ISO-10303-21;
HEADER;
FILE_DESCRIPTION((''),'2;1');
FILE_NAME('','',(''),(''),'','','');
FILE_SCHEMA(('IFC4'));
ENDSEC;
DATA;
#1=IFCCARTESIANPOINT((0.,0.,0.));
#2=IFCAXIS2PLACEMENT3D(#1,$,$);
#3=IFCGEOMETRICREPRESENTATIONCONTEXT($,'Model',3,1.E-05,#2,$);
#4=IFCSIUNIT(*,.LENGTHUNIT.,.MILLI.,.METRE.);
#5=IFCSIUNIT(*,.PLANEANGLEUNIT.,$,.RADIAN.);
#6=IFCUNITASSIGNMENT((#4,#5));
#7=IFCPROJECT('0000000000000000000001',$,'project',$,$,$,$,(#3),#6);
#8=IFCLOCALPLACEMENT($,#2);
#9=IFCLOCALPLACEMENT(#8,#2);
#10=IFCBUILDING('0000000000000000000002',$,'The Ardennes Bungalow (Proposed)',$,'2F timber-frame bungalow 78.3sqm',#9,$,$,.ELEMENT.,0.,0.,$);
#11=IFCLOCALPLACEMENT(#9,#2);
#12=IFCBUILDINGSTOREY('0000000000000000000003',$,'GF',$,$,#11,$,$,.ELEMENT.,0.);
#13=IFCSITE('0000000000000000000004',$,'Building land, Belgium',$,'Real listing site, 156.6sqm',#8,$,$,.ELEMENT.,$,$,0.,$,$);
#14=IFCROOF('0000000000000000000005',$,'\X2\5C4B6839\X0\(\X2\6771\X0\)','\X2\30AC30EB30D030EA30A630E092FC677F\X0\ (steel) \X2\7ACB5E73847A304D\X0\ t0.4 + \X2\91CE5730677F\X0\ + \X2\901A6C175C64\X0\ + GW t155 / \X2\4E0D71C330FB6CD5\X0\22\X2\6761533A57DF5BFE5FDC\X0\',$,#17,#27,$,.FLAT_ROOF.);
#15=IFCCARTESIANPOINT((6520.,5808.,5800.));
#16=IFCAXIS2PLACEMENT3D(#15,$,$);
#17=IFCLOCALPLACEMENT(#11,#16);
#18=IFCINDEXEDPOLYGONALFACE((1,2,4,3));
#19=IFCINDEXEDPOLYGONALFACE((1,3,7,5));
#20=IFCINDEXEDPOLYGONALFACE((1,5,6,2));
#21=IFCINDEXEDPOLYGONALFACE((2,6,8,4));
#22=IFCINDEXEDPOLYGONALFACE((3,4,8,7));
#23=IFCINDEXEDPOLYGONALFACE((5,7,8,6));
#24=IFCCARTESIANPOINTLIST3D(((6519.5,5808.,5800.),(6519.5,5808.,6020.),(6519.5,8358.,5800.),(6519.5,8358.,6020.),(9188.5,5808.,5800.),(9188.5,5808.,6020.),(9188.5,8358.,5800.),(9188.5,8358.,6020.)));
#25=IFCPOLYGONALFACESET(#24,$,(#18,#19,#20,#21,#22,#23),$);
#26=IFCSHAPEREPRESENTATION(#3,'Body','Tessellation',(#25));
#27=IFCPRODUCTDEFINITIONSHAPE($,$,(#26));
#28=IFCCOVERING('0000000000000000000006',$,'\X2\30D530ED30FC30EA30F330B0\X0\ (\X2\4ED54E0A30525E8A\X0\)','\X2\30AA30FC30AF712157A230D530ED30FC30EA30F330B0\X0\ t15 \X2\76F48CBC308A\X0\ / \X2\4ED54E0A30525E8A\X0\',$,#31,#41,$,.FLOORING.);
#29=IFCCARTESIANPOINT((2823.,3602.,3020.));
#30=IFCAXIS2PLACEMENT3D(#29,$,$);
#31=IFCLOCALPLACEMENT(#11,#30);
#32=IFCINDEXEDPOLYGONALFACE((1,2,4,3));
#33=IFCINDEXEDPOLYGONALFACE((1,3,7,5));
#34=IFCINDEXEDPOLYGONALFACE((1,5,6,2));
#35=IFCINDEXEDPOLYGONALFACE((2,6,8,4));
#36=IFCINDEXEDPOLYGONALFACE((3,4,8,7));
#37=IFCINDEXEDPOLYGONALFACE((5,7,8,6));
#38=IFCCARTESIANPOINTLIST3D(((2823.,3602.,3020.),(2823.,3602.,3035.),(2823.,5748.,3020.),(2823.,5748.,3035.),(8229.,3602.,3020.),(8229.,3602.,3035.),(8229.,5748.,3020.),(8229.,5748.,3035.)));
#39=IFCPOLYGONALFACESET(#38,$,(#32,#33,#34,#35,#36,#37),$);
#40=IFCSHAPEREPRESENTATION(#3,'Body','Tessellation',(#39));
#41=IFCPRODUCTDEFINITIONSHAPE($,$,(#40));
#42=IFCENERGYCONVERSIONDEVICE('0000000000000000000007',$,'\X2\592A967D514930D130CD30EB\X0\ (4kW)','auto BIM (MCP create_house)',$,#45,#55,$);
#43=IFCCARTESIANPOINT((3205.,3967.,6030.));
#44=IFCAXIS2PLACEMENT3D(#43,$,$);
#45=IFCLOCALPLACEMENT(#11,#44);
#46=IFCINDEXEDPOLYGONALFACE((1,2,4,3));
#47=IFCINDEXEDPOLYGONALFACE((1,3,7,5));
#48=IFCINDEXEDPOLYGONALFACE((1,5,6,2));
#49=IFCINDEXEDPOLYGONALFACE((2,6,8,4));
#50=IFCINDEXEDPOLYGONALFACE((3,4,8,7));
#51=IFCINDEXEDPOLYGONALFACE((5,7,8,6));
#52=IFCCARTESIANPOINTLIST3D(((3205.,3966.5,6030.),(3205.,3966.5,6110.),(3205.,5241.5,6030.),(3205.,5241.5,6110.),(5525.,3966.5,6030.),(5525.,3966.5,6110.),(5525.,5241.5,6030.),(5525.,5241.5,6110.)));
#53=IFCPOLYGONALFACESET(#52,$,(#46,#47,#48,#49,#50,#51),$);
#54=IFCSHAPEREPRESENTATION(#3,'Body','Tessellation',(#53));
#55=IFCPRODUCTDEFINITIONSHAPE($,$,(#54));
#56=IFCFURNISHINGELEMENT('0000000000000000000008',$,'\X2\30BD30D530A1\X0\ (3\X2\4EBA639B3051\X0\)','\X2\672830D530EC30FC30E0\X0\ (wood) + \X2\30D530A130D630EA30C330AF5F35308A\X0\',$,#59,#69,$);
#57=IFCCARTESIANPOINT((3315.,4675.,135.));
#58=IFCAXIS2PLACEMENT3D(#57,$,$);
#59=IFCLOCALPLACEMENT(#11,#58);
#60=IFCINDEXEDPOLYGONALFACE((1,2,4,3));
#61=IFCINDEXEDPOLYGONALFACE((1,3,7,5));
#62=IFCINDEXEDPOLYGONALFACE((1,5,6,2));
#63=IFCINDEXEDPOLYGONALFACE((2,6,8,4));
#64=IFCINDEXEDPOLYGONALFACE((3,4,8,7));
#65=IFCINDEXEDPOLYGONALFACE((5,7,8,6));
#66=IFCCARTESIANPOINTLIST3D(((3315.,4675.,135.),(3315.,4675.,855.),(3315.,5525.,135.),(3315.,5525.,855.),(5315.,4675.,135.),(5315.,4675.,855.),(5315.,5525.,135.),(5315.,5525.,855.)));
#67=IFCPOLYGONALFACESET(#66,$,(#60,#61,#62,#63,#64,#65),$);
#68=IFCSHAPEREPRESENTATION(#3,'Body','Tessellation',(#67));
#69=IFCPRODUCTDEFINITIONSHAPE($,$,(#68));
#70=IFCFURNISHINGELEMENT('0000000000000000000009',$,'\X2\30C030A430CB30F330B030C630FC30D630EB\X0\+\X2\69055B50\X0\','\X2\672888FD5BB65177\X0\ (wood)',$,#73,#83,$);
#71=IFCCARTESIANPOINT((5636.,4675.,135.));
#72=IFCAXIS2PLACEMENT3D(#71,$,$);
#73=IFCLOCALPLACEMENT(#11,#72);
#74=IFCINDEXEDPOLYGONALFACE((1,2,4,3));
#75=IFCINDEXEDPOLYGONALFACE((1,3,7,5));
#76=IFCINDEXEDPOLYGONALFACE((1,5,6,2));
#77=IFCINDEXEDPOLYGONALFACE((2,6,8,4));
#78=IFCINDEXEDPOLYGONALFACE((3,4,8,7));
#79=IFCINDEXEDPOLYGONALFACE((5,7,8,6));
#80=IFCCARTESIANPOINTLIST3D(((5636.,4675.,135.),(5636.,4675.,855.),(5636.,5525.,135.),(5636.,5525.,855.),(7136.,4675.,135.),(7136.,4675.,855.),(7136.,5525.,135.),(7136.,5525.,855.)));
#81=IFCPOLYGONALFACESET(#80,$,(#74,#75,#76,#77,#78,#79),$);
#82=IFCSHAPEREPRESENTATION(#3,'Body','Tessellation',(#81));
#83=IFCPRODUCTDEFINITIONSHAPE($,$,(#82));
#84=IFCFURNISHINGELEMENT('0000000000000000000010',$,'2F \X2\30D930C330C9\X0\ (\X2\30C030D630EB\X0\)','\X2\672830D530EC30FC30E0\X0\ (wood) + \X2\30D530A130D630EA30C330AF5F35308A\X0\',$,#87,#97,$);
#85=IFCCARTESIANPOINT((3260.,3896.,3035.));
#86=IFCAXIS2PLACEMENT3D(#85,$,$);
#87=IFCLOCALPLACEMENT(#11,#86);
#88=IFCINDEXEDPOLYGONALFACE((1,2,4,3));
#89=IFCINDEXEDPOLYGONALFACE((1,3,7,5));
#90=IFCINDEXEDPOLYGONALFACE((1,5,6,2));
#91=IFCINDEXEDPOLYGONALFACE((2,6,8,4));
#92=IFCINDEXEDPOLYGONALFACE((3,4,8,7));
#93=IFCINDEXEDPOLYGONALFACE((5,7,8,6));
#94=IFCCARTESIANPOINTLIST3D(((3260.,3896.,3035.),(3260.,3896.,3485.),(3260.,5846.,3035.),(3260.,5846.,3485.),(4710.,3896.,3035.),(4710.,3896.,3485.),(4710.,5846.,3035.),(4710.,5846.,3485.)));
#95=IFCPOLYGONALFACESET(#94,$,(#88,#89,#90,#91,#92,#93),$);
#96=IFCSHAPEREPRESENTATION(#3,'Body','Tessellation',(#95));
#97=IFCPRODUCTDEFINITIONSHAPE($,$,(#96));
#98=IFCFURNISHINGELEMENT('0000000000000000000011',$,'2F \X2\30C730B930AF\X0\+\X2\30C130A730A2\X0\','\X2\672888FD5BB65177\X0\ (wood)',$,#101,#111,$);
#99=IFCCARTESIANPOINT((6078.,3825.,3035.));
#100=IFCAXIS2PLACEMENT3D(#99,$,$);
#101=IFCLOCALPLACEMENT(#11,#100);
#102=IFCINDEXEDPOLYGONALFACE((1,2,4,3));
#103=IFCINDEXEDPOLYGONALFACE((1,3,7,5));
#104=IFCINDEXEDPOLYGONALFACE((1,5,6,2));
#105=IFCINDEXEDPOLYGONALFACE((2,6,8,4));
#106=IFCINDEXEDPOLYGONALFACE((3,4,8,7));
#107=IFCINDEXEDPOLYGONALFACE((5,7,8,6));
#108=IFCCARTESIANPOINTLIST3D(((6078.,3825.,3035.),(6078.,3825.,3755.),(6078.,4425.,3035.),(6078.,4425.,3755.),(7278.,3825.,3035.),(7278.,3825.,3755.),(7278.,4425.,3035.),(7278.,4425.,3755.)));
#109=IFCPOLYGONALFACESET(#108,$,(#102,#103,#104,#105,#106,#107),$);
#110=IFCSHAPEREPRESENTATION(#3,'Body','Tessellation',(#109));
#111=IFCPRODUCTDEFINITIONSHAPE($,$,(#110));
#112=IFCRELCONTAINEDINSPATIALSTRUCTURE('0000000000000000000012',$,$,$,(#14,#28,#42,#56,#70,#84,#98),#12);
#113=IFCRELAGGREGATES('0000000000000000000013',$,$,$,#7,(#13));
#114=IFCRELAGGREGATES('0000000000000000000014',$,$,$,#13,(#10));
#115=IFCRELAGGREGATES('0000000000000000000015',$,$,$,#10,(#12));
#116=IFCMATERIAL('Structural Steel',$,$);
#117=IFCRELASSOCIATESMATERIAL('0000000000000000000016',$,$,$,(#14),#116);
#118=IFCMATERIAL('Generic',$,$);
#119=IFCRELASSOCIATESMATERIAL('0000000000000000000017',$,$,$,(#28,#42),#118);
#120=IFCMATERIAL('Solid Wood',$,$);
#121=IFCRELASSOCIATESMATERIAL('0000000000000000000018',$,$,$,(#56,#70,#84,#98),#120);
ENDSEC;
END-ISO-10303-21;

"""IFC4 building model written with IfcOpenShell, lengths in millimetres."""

from ifc_helpers import new_model, si_unit, frame, frame_2d, origin, place, context, project, spatial, rectangle, extrude, material, element, save


model = new_model("IFC4")

# Units and contexts
model_context = context("Model", 3, precision=1e-05, world=origin())
ifc_project = project(units=[si_unit("LENGTHUNIT", "METRE", prefix="MILLI"), si_unit("PLANEANGLEUNIT", "RADIAN")], contexts=[model_context])

# Site, building, storey
site_placement = place(None, origin())
site = spatial("IfcSite", under=ifc_project, at=site_placement, Name="Building land, Belgium", ObjectType="Real listing site, 156.6sqm", CompositionType="ELEMENT", RefElevation=0.0)
building_placement = place(site_placement, origin())
building = spatial("IfcBuilding", under=site, at=building_placement, Name="The Ardennes Bungalow (Proposed)", ObjectType="2F timber-frame bungalow 78.3sqm", CompositionType="ELEMENT", ElevationOfRefHeight=0.0, ElevationOfTerrain=0.0)
storey_placement = place(building_placement, origin())
storey = spatial("IfcBuildingStorey", under=building, at=storey_placement, Name="GF", CompositionType="ELEMENT", Elevation=0.0)

# Shared definitions
ifc_material_1 = material(Name="Solid Wood")

# Roof
ifc_material_2 = material(Name="Structural Steel")
roof_1_placement = place(storey_placement, frame((6520.0, 5808.0, 5800.0)))
element("IfcRoof", 1, at=roof_1_placement, inside=storey, material=ifc_material_2, Name="屋根(東)", Description="ガルバリウム鋼板 (steel) 立平葺き t0.4 + 野地板 + 通気層 + GW t155 / 不燃・法22条区域対応", PredefinedType="FLAT_ROOF", context=model_context, shape_type="SweptSolid", body=[
    extrude(rectangle(XDim=2669.0, YDim=2550.0, at=frame_2d((1334.0, 1275.0))), frame((6520.0, 5808.0, 5800.0)), (0.0, 0.0, 1.0), 220.0),
])

# Covering
ifc_material_3 = material(Name="Generic")
covering_placement = place(storey_placement, frame((2823.0, 3602.0, 3020.0)))
element("IfcCovering", 2, at=covering_placement, inside=storey, material=ifc_material_3, Name="フローリング (仕上げ床)", Description="オーク無垢フローリング t15 直貼り / 仕上げ床", PredefinedType="FLOORING", context=model_context, shape_type="SweptSolid", body=[
    extrude(rectangle(XDim=5406.0, YDim=2146.0, at=frame_2d((2703.0, 1073.0))), frame((2823.0, 3602.0, 3020.0)), (0.0, 0.0, 1.0), 15.0),
])

# Energy conversion device
energy_conversion_device_placement = place(storey_placement, frame((3205.0, 3967.0, 6030.0)))
element("IfcEnergyConversionDevice", 3, at=energy_conversion_device_placement, inside=storey, material=ifc_material_3, Name="太陽光パネル (4kW)", Description="auto BIM (MCP create_house)", context=model_context, shape_type="SweptSolid", body=[
    extrude(rectangle(XDim=2320.0, YDim=1275.0, at=frame_2d((1160.0, 637.0))), frame((3205.0, 3967.0, 6030.0)), (0.0, 0.0, 1.0), 80.0),
])

# Furnishing elements
furnishing_1_placement = place(storey_placement, frame((3315.0, 4675.0, 135.0)))
element("IfcFurnishingElement", 4, at=furnishing_1_placement, inside=storey, material=ifc_material_1, Name="ソファ (3人掛け)", Description="木フレーム (wood) + ファブリック張り", context=model_context, shape_type="SweptSolid", body=[
    extrude(rectangle(XDim=2000.0, YDim=850.0, at=frame_2d((1000.0, 425.0))), frame((3315.0, 4675.0, 135.0)), (0.0, 0.0, 1.0), 720.0),
])
furnishing_2_placement = place(storey_placement, frame((5636.0, 4675.0, 135.0)))
element("IfcFurnishingElement", 5, at=furnishing_2_placement, inside=storey, material=ifc_material_1, Name="ダイニングテーブル+椅子", Description="木製家具 (wood)", context=model_context, shape_type="SweptSolid", body=[
    extrude(rectangle(XDim=1500.0, YDim=850.0, at=frame_2d((750.0, 425.0))), frame((5636.0, 4675.0, 135.0)), (0.0, 0.0, 1.0), 720.0),
])
furnishing_3_placement = place(storey_placement, frame((3260.0, 3896.0, 3035.0)))
element("IfcFurnishingElement", 6, at=furnishing_3_placement, inside=storey, material=ifc_material_1, Name="2F ベッド (ダブル)", Description="木フレーム (wood) + ファブリック張り", context=model_context, shape_type="SweptSolid", body=[
    extrude(rectangle(XDim=1450.0, YDim=1950.0, at=frame_2d((725.0, 975.0))), frame((3260.0, 3896.0, 3035.0)), (0.0, 0.0, 1.0), 450.0),
])
furnishing_4_placement = place(storey_placement, frame((6078.0, 3825.0, 3035.0)))
element("IfcFurnishingElement", 7, at=furnishing_4_placement, inside=storey, material=ifc_material_1, Name="2F デスク+チェア", Description="木製家具 (wood)", context=model_context, shape_type="SweptSolid", body=[
    extrude(rectangle(XDim=1200.0, YDim=600.0, at=frame_2d((600.0, 300.0))), frame((6078.0, 3825.0, 3035.0)), (0.0, 0.0, 1.0), 720.0),
])

save(model, "model.ifc")
